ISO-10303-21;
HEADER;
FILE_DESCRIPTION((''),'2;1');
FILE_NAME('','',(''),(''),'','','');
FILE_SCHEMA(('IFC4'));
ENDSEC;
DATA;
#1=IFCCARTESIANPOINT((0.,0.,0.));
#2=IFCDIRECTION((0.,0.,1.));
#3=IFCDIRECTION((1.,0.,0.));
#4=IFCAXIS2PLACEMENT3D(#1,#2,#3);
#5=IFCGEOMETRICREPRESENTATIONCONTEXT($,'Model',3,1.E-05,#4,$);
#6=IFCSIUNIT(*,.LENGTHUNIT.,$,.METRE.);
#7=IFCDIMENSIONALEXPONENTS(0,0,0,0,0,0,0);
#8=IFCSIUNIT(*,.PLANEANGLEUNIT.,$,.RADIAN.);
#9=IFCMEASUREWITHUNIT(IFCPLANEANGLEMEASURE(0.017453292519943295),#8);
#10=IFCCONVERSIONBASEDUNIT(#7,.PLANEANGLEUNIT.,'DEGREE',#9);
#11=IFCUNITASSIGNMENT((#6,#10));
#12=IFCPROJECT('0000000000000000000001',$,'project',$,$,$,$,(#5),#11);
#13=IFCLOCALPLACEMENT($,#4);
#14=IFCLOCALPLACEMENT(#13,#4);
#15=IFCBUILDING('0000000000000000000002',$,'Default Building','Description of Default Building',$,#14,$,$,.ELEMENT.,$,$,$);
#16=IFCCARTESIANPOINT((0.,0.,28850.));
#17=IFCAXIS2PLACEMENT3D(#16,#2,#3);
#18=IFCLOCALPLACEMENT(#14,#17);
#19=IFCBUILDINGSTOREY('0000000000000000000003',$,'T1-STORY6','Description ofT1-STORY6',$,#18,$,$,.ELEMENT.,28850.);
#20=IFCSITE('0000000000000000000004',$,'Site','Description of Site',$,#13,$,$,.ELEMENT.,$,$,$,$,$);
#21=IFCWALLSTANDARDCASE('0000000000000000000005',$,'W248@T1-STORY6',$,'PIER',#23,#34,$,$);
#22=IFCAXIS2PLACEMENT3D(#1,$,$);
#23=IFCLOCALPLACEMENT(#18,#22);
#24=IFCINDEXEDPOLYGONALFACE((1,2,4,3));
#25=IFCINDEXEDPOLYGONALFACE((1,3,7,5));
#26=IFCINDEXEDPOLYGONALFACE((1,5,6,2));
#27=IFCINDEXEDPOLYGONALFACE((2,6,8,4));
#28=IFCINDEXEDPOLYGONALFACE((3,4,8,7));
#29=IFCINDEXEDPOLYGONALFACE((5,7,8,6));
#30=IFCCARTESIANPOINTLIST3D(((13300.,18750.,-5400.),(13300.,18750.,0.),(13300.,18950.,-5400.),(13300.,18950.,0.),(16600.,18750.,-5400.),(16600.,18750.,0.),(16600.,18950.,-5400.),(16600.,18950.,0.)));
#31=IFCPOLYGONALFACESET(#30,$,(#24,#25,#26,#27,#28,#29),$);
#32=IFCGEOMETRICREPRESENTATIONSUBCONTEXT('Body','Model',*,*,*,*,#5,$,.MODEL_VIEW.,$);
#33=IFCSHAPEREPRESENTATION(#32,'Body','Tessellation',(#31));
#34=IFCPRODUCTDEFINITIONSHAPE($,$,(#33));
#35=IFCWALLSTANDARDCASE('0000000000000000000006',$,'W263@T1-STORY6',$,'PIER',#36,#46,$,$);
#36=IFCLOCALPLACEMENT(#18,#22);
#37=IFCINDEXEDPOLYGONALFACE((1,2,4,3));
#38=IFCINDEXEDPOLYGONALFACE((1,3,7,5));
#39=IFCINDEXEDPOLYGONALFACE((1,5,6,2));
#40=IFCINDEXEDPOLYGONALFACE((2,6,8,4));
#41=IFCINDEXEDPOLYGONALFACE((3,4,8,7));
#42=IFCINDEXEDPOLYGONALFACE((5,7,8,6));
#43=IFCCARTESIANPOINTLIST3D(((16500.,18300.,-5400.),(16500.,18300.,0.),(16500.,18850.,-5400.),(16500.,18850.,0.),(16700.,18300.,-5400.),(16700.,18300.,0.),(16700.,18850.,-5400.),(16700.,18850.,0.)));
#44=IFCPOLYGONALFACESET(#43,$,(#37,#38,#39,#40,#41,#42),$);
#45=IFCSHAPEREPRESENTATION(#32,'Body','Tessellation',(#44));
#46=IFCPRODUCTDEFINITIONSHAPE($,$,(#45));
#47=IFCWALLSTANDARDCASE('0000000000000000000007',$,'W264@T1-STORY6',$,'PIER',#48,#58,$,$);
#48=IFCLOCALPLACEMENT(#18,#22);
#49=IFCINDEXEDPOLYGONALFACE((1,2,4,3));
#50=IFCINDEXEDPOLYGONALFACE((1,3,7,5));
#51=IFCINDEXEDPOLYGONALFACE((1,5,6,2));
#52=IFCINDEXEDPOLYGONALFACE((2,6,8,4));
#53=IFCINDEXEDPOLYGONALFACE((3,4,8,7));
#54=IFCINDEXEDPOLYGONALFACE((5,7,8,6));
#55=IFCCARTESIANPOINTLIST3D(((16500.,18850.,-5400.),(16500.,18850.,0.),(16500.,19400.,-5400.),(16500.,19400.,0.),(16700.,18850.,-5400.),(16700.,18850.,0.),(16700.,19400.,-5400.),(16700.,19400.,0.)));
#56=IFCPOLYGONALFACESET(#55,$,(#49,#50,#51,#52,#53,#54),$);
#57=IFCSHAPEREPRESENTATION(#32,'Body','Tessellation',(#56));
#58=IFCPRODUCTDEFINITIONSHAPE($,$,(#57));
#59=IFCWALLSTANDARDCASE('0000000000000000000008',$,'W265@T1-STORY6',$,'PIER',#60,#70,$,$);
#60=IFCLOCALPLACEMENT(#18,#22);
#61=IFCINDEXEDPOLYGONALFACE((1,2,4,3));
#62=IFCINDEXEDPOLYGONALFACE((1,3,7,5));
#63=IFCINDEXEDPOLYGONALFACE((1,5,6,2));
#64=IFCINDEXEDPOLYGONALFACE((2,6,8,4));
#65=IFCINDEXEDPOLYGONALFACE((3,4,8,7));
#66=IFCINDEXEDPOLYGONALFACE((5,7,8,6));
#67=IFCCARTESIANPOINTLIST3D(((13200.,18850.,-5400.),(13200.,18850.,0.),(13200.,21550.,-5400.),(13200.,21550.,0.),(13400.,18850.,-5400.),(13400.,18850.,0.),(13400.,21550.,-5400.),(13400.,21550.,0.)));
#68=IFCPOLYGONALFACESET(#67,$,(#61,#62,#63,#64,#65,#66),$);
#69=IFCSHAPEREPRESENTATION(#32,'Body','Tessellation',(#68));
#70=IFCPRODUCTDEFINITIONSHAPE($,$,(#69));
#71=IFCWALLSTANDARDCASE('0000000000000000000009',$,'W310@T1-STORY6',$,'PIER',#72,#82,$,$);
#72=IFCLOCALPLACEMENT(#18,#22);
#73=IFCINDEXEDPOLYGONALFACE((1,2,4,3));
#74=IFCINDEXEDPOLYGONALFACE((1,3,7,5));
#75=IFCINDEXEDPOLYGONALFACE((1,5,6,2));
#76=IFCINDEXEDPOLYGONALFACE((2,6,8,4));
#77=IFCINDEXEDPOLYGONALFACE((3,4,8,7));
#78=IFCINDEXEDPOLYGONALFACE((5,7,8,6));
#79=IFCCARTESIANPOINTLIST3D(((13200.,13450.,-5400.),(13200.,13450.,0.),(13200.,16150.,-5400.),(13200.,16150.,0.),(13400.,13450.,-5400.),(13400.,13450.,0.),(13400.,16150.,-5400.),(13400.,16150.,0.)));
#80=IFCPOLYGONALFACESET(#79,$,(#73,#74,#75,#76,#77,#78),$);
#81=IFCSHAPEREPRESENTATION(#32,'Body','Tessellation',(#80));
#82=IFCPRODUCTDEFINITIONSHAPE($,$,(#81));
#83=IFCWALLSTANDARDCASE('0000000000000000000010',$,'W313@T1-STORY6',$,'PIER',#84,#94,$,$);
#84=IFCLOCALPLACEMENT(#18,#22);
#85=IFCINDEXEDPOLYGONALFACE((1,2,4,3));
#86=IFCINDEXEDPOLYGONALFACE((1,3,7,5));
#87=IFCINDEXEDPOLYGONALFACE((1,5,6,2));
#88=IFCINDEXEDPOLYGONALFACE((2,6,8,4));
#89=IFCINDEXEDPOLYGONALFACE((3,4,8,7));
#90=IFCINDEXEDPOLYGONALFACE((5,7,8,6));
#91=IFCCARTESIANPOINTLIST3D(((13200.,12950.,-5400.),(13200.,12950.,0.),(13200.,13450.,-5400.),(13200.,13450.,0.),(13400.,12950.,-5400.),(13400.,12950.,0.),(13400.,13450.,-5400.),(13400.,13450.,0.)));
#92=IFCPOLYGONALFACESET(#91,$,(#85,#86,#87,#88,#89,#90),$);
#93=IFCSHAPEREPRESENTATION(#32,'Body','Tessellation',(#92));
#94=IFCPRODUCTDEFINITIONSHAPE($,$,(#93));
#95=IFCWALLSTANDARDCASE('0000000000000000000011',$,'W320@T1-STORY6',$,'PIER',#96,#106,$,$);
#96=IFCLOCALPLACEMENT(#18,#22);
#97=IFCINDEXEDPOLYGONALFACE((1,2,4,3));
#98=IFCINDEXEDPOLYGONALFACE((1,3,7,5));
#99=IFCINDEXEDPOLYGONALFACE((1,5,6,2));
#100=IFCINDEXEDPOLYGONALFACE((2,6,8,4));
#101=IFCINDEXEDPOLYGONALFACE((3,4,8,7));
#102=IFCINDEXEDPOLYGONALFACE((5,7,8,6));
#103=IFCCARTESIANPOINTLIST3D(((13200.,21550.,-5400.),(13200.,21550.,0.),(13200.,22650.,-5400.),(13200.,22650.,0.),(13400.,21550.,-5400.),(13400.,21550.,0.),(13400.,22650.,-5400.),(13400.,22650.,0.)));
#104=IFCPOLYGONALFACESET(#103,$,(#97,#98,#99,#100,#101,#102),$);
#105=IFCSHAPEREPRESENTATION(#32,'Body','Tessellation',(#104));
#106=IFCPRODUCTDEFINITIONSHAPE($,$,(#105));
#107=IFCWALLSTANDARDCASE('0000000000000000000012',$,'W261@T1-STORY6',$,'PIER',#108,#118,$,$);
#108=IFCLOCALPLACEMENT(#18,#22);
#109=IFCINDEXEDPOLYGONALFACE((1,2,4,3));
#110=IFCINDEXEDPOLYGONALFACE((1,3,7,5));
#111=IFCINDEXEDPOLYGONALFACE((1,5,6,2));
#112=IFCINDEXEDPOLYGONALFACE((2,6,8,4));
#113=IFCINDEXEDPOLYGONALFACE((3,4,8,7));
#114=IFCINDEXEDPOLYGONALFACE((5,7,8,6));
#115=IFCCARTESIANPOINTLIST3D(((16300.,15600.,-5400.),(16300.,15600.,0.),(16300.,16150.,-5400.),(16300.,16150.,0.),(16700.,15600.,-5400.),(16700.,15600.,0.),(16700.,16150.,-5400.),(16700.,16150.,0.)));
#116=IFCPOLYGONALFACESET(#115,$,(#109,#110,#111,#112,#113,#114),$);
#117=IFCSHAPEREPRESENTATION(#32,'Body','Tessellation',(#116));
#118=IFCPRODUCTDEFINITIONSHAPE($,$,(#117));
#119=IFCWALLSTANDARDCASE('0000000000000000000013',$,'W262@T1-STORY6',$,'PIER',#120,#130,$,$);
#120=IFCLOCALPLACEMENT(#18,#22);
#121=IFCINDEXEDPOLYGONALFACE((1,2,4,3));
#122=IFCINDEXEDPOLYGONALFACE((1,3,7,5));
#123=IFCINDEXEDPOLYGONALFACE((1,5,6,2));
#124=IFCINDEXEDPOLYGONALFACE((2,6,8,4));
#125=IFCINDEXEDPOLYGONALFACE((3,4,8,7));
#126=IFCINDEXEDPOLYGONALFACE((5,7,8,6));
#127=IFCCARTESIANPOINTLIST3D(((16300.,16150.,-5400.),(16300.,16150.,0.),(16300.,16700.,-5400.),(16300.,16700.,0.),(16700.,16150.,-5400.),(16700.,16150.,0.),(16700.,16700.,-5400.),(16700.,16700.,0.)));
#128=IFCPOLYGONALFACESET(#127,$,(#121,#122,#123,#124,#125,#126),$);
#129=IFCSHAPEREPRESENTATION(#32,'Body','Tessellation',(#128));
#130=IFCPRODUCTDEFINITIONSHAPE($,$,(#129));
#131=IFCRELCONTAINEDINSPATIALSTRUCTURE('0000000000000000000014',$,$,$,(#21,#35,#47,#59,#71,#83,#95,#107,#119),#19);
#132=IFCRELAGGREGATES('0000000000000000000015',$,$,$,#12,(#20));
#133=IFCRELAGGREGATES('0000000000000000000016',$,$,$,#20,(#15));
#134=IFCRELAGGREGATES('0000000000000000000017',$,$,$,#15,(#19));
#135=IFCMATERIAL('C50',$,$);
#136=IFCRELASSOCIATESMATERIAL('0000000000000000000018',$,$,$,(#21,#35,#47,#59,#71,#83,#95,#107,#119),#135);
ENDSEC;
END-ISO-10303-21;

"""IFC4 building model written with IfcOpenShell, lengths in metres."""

from ifc_helpers import new_model, entity, si_unit, converted_unit, frame, origin_with_axes, place, context, subcontext, project, spatial, indexed_curve, outline, extrude, material, element, save


model = new_model("IFC4")

# Units and contexts
model_context = context("Model", 3, precision=1e-05, world=origin_with_axes())
body_context = subcontext(model_context, "Body", "Model", "MODEL_VIEW")
ifc_project = project(units=[si_unit("LENGTHUNIT", "METRE"), converted_unit("PLANEANGLEUNIT", "DEGREE", entity("IfcPlaneAngleMeasure", 0.017453292519943295), si_unit("PLANEANGLEUNIT", "RADIAN"), dimensions=[0, 0, 0, 0, 0, 0, 0])], contexts=[model_context])

# Site, building, storey
site_placement = place(None, origin_with_axes())
site = spatial("IfcSite", under=ifc_project, at=site_placement, Name="Site", Description="Description of Site", CompositionType="ELEMENT")
building_placement = place(site_placement, origin_with_axes())
building = spatial("IfcBuilding", under=site, at=building_placement, Name="Default Building", Description="Description of Default Building", CompositionType="ELEMENT")
storey_placement = place(building_placement, frame((0.0, 0.0, 28850.0), z_axis=(0.0, 0.0, 1.0), x_axis=(1.0, 0.0, 0.0)))
storey = spatial("IfcBuildingStorey", under=building, at=storey_placement, Name="T1-STORY6", Description="Description ofT1-STORY6", CompositionType="ELEMENT", Elevation=28850.0)

# Shared definitions
ifc_material_1 = material(Name="C50")

# Walls
wall_1_placement = place(storey_placement, frame((13300.0, 18850.0, -5400.0), z_axis=(0.0, 0.0, 1.0), x_axis=(1.0, 0.0, 0.0)))
element("IfcWallStandardCase", 1, at=wall_1_placement, inside=storey, material=ifc_material_1, Name="W248@T1-STORY6", ObjectType="PIER", context=body_context, shape_type="SweptSolid", body=[
    extrude(outline(indexed_curve([(0.0, -100.0), (0.0, 100.0), (3300.0, 100.0), (3300.0, -100.0), (0.0, -100.0)], self_intersect=False)), origin_with_axes(), (0.0, 0.0, 1.0), 5400.0),
])
for number, where, z_axis, x_axis, name in (
    (2, (16600.0, 18300.0, -5400.0), (0.0, 0.0, 1.0), (0.0, 1.0, 0.0), "W263@T1-STORY6"),
    (3, (16600.0, 18850.0, -5400.0), (0.0, 0.0, 1.0), (0.0, 1.0, 0.0), "W264@T1-STORY6"),
):
    element("IfcWallStandardCase", number, at=place(storey_placement, frame(where, z_axis=z_axis, x_axis=x_axis)), inside=storey, material=ifc_material_1, Name=name, ObjectType="PIER", context=body_context, shape_type="SweptSolid", body=[
        extrude(outline(indexed_curve([(0.0, -100.0), (0.0, 100.0), (550.0, 100.0), (550.0, -100.0), (0.0, -100.0)], self_intersect=False)), origin_with_axes(), (0.0, 0.0, 1.0), 5400.0),
    ])
for number, where, z_axis, x_axis, name in (
    (4, (13300.0, 18850.0, -5400.0), (0.0, 0.0, 1.0), (0.0, 1.0, 0.0), "W265@T1-STORY6"),
    (5, (13300.0, 13450.0, -5400.0), (0.0, 0.0, 1.0), (0.0, 1.0, 0.0), "W310@T1-STORY6"),
):
    element("IfcWallStandardCase", number, at=place(storey_placement, frame(where, z_axis=z_axis, x_axis=x_axis)), inside=storey, material=ifc_material_1, Name=name, ObjectType="PIER", context=body_context, shape_type="SweptSolid", body=[
        extrude(outline(indexed_curve([(0.0, -100.0), (0.0, 100.0), (2700.0, 100.0), (2700.0, -100.0), (0.0, -100.0)], self_intersect=False)), origin_with_axes(), (0.0, 0.0, 1.0), 5400.0),
    ])
wall_2_placement = place(storey_placement, frame((13300.0, 12950.0, -5400.0), z_axis=(0.0, 0.0, 1.0), x_axis=(0.0, 1.0, 0.0)))
element("IfcWallStandardCase", 6, at=wall_2_placement, inside=storey, material=ifc_material_1, Name="W313@T1-STORY6", ObjectType="PIER", context=body_context, shape_type="SweptSolid", body=[
    extrude(outline(indexed_curve([(0.0, -100.0), (0.0, 100.0), (500.0, 100.0), (500.0, -100.0), (0.0, -100.0)], self_intersect=False)), origin_with_axes(), (0.0, 0.0, 1.0), 5400.0),
])
wall_3_placement = place(storey_placement, frame((13300.0, 21550.0, -5400.0), z_axis=(0.0, 0.0, 1.0), x_axis=(0.0, 1.0, 0.0)))
element("IfcWallStandardCase", 7, at=wall_3_placement, inside=storey, material=ifc_material_1, Name="W320@T1-STORY6", ObjectType="PIER", context=body_context, shape_type="SweptSolid", body=[
    extrude(outline(indexed_curve([(0.0, -100.0), (0.0, 100.0), (1100.0, 100.0), (1100.0, -100.0), (0.0, -100.0)], self_intersect=False)), origin_with_axes(), (0.0, 0.0, 1.0), 5400.0),
])
for number, where, z_axis, x_axis, name in (
    (8, (16500.0, 15600.0, -5400.0), (0.0, 0.0, 1.0), (0.0, 1.0, 0.0), "W261@T1-STORY6"),
    (9, (16500.0, 16150.0, -5400.0), (0.0, 0.0, 1.0), (0.0, 1.0, 0.0), "W262@T1-STORY6"),
):
    element("IfcWallStandardCase", number, at=place(storey_placement, frame(where, z_axis=z_axis, x_axis=x_axis)), inside=storey, material=ifc_material_1, Name=name, ObjectType="PIER", context=body_context, shape_type="SweptSolid", body=[
        extrude(outline(indexed_curve([(0.0, -200.0), (0.0, 200.0), (550.0, 200.0), (550.0, -200.0), (0.0, -200.0)], self_intersect=False)), origin_with_axes(), (0.0, 0.0, 1.0), 5400.0),
    ])

save(model, "model.ifc")
